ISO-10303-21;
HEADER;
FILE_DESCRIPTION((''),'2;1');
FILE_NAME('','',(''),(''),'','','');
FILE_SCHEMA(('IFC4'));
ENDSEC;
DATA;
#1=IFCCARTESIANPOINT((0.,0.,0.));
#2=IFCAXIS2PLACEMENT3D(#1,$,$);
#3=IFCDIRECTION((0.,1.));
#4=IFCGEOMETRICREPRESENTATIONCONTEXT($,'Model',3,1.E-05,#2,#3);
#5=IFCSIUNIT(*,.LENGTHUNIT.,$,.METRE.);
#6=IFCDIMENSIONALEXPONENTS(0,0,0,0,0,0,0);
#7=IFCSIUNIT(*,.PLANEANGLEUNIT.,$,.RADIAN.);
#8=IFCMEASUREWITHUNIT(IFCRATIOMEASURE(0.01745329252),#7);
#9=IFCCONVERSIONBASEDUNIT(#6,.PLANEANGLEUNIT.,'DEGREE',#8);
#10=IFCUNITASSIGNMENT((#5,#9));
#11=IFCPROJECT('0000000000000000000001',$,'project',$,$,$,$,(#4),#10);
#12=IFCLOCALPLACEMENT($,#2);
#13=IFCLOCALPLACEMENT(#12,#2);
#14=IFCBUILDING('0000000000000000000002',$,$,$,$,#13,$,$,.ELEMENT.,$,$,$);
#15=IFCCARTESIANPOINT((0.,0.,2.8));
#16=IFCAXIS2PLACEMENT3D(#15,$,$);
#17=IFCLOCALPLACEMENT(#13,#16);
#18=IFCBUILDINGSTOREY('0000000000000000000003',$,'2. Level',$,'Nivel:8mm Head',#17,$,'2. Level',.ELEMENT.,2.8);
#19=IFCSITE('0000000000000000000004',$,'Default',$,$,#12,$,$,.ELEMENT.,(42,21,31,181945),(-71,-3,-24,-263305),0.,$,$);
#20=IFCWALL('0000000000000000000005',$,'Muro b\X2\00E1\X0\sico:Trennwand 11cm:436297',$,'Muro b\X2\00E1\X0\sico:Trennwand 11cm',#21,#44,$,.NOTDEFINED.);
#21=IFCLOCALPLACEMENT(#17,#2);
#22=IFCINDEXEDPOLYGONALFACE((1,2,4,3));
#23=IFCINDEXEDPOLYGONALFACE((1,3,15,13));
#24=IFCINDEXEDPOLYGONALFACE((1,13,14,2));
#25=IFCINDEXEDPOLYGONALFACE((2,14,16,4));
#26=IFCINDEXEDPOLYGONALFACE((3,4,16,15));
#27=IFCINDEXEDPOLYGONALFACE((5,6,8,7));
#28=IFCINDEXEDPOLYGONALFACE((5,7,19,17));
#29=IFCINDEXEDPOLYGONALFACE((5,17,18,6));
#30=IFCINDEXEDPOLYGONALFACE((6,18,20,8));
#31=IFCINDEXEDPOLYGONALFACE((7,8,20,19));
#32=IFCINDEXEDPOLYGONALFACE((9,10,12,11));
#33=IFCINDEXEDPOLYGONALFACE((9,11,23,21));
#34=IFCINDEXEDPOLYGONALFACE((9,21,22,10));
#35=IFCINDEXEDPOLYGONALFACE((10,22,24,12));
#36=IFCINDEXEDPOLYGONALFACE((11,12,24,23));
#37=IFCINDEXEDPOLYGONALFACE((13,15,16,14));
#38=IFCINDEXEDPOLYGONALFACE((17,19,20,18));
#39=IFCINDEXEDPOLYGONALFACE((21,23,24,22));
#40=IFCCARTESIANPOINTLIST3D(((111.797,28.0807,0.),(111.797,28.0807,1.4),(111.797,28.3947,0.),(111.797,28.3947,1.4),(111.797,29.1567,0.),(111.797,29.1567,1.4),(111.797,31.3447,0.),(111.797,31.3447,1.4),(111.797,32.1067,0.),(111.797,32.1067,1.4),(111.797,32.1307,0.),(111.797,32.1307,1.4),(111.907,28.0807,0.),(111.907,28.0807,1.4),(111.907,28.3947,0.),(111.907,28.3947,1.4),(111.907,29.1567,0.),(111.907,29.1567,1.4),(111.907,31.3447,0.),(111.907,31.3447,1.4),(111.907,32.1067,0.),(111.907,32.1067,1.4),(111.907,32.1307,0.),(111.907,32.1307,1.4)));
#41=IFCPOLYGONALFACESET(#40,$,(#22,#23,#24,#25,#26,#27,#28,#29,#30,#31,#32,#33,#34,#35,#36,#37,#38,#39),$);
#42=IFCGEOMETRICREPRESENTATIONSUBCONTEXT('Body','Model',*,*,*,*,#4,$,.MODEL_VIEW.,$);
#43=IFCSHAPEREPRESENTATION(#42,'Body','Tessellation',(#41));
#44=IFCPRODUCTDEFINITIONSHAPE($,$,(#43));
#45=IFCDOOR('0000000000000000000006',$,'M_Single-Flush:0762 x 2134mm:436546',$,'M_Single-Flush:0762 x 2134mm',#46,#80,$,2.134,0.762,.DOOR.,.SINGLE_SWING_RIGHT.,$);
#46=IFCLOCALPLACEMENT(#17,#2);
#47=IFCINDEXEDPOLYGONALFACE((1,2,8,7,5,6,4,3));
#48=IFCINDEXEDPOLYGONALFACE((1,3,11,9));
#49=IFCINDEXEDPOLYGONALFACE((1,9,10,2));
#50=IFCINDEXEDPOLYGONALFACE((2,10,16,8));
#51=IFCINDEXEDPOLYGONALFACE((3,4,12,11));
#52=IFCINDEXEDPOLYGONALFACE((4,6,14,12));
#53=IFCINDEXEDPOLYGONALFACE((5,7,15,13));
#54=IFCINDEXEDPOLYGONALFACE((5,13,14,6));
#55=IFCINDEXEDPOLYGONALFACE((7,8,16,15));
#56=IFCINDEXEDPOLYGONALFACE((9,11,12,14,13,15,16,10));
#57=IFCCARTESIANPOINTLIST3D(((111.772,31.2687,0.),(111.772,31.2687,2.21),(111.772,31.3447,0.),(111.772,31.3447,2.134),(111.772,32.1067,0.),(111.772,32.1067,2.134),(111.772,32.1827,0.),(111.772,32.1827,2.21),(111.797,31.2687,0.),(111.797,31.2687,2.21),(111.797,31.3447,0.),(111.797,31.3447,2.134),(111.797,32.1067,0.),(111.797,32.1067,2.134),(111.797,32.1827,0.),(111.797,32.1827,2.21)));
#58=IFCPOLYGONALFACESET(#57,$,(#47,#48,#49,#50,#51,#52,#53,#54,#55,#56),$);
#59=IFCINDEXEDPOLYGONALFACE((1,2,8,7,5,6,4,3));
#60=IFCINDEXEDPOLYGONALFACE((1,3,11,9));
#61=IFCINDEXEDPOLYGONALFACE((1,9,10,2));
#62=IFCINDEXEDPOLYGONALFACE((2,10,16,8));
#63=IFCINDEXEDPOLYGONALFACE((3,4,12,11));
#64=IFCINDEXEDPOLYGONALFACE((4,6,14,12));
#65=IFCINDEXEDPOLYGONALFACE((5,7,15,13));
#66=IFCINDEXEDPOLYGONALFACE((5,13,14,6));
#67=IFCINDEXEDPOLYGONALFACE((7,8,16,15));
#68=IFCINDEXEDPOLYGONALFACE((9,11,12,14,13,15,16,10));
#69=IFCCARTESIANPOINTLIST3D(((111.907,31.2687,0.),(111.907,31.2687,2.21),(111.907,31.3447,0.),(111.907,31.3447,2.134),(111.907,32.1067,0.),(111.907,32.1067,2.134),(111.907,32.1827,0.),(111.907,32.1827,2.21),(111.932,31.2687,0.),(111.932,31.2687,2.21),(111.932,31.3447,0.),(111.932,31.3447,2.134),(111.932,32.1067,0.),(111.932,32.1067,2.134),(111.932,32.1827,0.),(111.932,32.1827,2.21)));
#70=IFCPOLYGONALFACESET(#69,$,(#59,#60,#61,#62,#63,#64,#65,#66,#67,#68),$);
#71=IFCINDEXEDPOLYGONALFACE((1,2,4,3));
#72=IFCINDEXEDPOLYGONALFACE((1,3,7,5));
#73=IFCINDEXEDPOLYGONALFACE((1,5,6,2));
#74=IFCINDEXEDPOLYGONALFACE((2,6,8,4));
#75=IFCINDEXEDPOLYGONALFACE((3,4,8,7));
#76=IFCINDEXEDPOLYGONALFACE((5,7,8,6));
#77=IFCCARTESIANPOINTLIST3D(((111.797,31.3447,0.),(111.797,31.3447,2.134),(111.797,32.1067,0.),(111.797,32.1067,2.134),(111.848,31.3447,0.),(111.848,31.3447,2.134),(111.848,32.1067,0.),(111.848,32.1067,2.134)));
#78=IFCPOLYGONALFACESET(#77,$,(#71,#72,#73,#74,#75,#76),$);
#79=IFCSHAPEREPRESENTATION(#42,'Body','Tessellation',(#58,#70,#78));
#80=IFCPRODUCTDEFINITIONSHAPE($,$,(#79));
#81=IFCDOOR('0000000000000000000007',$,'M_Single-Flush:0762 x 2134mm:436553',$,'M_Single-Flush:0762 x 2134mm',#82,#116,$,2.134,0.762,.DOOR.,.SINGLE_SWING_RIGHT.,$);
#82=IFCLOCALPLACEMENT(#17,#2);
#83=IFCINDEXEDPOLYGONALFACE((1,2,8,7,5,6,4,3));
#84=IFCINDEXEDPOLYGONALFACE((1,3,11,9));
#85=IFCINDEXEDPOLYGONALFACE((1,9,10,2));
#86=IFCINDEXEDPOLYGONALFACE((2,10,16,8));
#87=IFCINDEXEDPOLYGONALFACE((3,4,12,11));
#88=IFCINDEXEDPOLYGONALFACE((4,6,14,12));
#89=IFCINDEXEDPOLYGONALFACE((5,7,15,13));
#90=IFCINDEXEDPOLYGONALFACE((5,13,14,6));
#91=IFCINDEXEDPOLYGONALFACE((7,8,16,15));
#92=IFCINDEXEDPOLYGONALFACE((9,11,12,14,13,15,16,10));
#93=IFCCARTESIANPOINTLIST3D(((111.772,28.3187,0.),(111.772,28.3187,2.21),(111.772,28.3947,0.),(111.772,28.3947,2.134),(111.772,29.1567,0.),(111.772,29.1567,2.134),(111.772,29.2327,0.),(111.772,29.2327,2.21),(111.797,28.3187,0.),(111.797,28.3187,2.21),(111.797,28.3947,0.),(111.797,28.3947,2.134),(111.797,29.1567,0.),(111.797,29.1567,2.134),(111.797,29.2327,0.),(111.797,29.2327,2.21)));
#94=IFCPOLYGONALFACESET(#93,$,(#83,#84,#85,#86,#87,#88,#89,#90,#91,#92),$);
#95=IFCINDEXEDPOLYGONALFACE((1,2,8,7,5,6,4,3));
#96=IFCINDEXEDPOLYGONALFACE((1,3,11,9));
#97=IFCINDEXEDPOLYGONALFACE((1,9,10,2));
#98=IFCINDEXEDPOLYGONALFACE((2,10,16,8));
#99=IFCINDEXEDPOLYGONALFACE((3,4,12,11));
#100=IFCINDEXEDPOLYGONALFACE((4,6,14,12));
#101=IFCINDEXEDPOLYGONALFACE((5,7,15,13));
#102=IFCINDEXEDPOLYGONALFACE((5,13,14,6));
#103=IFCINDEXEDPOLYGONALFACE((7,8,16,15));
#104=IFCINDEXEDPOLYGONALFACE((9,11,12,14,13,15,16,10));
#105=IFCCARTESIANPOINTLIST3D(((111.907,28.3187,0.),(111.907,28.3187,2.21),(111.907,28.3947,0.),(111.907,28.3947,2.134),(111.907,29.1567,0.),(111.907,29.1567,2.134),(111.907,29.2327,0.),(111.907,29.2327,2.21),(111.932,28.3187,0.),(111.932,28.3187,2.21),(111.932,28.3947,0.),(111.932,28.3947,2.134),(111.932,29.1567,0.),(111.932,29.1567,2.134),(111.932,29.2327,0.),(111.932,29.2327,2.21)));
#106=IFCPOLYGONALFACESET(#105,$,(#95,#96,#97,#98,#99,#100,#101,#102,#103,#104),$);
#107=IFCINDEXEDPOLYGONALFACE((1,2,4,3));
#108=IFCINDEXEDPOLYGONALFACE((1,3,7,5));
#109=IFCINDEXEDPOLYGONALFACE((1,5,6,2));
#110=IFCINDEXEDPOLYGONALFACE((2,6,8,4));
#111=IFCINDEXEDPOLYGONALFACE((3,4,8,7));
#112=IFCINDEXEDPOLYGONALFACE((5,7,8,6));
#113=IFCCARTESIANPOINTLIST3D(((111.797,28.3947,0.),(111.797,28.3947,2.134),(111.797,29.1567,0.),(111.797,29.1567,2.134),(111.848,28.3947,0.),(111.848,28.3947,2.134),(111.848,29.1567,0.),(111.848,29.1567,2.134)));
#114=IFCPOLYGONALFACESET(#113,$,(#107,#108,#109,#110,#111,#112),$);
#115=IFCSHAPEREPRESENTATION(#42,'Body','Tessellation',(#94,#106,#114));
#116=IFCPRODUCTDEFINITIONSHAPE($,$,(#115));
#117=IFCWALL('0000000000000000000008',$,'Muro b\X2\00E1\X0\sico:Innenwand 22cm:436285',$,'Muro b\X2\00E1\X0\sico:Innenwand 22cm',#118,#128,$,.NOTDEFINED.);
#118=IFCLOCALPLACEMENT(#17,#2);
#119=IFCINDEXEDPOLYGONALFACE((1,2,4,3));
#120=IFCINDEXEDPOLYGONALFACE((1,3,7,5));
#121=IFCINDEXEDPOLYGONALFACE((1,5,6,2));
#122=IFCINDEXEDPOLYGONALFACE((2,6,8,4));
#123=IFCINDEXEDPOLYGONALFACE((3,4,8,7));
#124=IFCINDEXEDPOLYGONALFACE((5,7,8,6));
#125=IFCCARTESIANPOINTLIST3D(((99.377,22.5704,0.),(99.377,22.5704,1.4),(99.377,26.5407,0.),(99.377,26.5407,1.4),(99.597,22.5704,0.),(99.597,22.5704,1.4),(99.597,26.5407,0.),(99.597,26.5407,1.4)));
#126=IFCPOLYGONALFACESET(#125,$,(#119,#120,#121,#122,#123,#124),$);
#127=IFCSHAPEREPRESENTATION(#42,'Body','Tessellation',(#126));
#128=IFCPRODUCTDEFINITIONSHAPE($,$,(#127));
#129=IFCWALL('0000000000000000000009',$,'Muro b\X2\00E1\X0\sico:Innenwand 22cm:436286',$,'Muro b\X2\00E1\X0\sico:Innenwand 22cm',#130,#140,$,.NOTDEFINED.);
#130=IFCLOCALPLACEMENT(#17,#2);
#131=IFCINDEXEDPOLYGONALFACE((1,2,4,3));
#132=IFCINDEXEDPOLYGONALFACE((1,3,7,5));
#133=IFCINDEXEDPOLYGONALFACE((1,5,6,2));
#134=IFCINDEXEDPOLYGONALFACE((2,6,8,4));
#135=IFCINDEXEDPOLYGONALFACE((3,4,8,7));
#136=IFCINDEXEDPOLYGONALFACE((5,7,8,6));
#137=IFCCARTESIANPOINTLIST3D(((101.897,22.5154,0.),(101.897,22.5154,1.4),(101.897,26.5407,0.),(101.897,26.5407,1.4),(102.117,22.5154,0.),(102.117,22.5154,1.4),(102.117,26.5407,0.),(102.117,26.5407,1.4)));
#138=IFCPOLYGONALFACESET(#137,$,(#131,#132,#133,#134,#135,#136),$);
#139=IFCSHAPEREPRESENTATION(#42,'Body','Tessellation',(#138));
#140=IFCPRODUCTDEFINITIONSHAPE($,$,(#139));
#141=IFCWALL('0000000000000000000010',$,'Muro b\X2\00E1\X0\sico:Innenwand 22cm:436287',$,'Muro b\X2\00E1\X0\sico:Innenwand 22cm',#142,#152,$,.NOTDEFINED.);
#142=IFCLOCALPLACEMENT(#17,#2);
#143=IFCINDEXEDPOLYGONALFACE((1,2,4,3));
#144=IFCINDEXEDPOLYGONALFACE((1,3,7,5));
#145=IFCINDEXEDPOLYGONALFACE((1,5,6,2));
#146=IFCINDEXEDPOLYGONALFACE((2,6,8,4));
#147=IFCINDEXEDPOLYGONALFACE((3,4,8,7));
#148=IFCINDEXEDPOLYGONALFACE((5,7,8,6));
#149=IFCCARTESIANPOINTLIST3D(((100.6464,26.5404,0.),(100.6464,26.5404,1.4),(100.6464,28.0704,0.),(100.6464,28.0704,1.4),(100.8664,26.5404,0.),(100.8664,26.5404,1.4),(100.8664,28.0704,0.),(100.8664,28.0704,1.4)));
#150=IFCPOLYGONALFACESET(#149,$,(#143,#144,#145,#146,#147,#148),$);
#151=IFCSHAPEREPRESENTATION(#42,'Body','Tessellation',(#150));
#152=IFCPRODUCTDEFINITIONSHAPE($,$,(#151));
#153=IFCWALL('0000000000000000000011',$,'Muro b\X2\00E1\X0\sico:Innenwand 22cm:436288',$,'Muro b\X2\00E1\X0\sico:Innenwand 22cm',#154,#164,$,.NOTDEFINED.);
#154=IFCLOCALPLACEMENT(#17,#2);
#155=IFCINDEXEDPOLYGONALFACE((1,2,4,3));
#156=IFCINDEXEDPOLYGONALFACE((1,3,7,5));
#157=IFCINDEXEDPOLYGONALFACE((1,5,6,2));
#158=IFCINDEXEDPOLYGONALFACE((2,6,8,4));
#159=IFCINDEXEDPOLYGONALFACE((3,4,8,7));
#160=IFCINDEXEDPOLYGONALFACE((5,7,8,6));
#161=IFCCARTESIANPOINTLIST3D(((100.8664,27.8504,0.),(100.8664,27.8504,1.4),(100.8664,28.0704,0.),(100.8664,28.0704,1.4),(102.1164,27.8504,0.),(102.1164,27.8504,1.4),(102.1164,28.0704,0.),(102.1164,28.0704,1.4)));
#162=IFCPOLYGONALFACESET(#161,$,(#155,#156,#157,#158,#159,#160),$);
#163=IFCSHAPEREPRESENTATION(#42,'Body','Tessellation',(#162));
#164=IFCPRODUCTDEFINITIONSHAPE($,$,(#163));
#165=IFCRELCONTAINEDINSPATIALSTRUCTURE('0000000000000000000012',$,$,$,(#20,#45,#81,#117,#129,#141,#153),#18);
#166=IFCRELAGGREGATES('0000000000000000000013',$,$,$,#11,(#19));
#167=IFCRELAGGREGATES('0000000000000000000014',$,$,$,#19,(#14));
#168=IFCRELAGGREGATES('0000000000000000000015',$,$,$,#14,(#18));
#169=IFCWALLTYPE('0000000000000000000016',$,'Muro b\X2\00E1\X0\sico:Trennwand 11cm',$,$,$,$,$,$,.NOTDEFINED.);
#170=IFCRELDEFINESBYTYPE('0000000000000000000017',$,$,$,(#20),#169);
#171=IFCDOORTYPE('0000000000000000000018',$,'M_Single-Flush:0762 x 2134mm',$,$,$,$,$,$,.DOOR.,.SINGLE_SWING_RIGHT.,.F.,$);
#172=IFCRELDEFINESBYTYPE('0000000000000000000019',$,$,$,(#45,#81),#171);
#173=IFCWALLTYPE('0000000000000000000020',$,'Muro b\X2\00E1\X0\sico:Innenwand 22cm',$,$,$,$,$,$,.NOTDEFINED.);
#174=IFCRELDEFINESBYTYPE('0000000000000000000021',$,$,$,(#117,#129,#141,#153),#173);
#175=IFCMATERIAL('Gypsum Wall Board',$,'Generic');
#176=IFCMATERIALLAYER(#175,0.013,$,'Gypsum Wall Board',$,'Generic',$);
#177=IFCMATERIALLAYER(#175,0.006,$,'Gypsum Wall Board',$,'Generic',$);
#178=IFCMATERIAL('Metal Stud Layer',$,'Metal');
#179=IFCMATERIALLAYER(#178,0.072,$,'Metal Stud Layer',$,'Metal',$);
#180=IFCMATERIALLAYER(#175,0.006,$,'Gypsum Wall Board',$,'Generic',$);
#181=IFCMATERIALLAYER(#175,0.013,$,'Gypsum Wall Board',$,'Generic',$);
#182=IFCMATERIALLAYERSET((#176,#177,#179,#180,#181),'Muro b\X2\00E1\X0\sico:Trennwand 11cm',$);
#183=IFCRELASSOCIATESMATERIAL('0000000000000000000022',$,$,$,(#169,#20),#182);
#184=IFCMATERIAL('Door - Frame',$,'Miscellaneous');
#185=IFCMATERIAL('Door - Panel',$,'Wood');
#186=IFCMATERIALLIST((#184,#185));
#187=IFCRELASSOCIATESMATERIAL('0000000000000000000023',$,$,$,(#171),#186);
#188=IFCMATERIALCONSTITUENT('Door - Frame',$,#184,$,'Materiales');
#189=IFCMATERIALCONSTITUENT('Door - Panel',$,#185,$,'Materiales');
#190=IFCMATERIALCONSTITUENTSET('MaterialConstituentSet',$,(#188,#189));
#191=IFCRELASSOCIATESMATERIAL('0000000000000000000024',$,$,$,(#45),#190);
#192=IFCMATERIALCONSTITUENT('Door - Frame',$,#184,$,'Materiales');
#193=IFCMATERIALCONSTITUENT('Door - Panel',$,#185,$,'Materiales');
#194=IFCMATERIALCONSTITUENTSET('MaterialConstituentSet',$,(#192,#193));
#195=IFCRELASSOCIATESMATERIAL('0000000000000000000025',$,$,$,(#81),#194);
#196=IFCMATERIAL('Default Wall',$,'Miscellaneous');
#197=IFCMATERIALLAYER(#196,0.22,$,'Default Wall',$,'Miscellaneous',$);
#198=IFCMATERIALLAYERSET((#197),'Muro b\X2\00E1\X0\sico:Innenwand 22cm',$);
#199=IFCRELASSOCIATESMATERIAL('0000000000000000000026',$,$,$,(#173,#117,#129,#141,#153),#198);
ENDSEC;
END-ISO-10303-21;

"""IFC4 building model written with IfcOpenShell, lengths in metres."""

from ifc_helpers import new_model, entity, si_unit, converted_unit, direction, frame, frame_2d, origin, origin_2d_with_axis, place, context, subcontext, project, spatial, polyline, rectangle, outline, extrude, clip, halfspace, source, transform, mapped, material, material_list, layer, layer_set, layer_usage, constituent, constituent_set, type_object, type_shapes, element, fill, save


model = new_model("IFC4")

# Units and contexts
model_context = context("Model", 3, precision=1e-05, world=origin(), true_north=direction((0.0, 1.0)))
body_context = subcontext(model_context, "Body", "Model", "MODEL_VIEW")
ifc_project = project(units=[si_unit("LENGTHUNIT", "METRE"), converted_unit("PLANEANGLEUNIT", "DEGREE", entity("IfcRatioMeasure", 0.01745329252), si_unit("PLANEANGLEUNIT", "RADIAN"), dimensions=[0, 0, 0, 0, 0, 0, 0])], contexts=[model_context])

# Site, building, storey
site_placement = place(None, origin())
site = spatial("IfcSite", under=ifc_project, at=site_placement, Name="Default", CompositionType="ELEMENT", RefLatitude=(42, 21, 31, 181945), RefLongitude=(-71, -3, -24, -263305), RefElevation=0.0)
building_placement = place(site_placement, origin())
building = spatial("IfcBuilding", under=site, at=building_placement, CompositionType="ELEMENT")
storey_placement = place(building_placement, frame((0.0, 0.0, 2.8)))
storey = spatial("IfcBuildingStorey", under=building, at=storey_placement, Name="2. Level", ObjectType="Nivel:8mm Head", LongName="2. Level", CompositionType="ELEMENT", Elevation=2.8)

# Shared definitions
ifc_material_1 = material(Name="Gypsum Wall Board", Category="Generic")
ifc_layer_1 = layer(ifc_material_1, 0.013, Name="Gypsum Wall Board", Category="Generic")
ifc_layer_2 = layer(ifc_material_1, 0.006, Name="Gypsum Wall Board", Category="Generic")
ifc_material_2 = material(Name="Metal Stud Layer", Category="Metal")
ifc_layer_3 = layer(ifc_material_2, 0.072, Name="Metal Stud Layer", Category="Metal")
ifc_layer_4 = layer(ifc_material_1, 0.006, Name="Gypsum Wall Board", Category="Generic")
ifc_layer_5 = layer(ifc_material_1, 0.013, Name="Gypsum Wall Board", Category="Generic")
ifc_layer_set_1 = layer_set([ifc_layer_1, ifc_layer_2, ifc_layer_3, ifc_layer_4, ifc_layer_5], Name="Muro básico:Trennwand 11cm")
wall_type_1 = type_object("IfcWallType", Name="Muro básico:Trennwand 11cm", PredefinedType="NOTDEFINED", material=ifc_layer_set_1)

# Shared definitions
ifc_material_3 = material(Name="Door - Frame", Category="Miscellaneous")
ifc_material_4 = material(Name="Door - Panel", Category="Wood")

# Wall, openings, doors
ifc_material_list_1 = material_list([ifc_material_3, ifc_material_4])
door_type_1 = type_object("IfcDoorType", Name="M_Single-Flush:0762 x 2134mm", OperationType="SINGLE_SWING_RIGHT", ParameterTakesPrecedence=False, PredefinedType="DOOR", material=ifc_material_list_1)
shared_shape_1 = source(origin(), body_context, "Body", "SweptSolid", [
    extrude(outline(polyline([(-0.457, -1.124), (0.457, -1.124), (0.457, 1.086), (0.381, 1.086), (0.381, -1.048), (-0.381, -1.048), (-0.381, 1.086), (-0.457, 1.086), (-0.457, -1.124)])), frame((0.381, 0.11, 1.086), z_axis=(0.0, 1.0, 0.0), x_axis=(1.0, 0.0, 0.0)), (0.0, 0.0, 1.0), 0.025),
    extrude(outline(polyline([(-1.124, -0.457), (1.086, -0.457), (1.086, -0.381), (-1.048, -0.381), (-1.048, 0.381), (1.086, 0.381), (1.086, 0.457), (-1.124, 0.457), (-1.124, -0.457)])), frame((0.381, -0.025, 1.086), z_axis=(0.0, 1.0, 0.0), x_axis=(0.0, 0.0, -1.0)), (0.0, 0.0, 1.0), 0.025),
    extrude(rectangle(XDim=0.051, YDim=0.762, at=origin_2d_with_axis()), frame((0.381, 0.0845, 0.0), z_axis=(0.0, 0.0, 1.0), x_axis=(0.0, 1.0, 0.0)), (0.0, 0.0, 1.0), 2.134),
])
type_shapes(door_type_1, [shared_shape_1])
ifc_layer_usage_1 = layer_usage(ifc_layer_set_1, "AXIS2", "NEGATIVE", 0.055)
wall_1_placement = place(storey_placement, frame((111.852, 28.0807, 0.0), z_axis=(0.0, 0.0, 1.0), x_axis=(0.0, 1.0, 0.0)))
wall_1 = element("IfcWall", 1, at=wall_1_placement, inside=storey, type_object=wall_type_1, material=ifc_layer_usage_1, Name="Muro básico:Trennwand 11cm:436297", ObjectType="Muro básico:Trennwand 11cm", PredefinedType="NOTDEFINED", context=body_context, shape_type="Clipping", body=[
    clip(extrude(rectangle(XDim=4.05, YDim=0.11, at=frame_2d((2.025, 0.0), x_axis=(-1.0, 0.0))), origin(), (0.0, 0.0, 1.0), 1.4), halfspace(origin(), True)),
])
opening_1_placement = place(wall_1_placement, frame((3.264, -0.055, 0.0)))
opening_1 = element("IfcOpeningElement", 2, at=opening_1_placement, cuts=wall_1, ObjectType="Opening", PredefinedType="OPENING", context=body_context, shape_type="SweptSolid", body=[
    extrude(rectangle(XDim=0.762, YDim=2.134, at=frame_2d((1.067, 0.381), x_axis=(0.0, 1.0))), frame((0.0, 0.0, 0.0), z_axis=(0.0, 1.0, 0.0), x_axis=(0.0, 0.0, 1.0)), (0.0, 0.0, 1.0), 0.11),
])
opening_2_placement = place(wall_1_placement, frame((0.314, -0.055, 0.0)))
opening_2 = element("IfcOpeningElement", 3, at=opening_2_placement, cuts=wall_1, ObjectType="Opening", PredefinedType="OPENING", context=body_context, shape_type="SweptSolid", body=[
    extrude(rectangle(XDim=0.762, YDim=2.134, at=frame_2d((1.067, 0.381), x_axis=(0.0, 1.0))), frame((0.0, 0.0, 0.0), z_axis=(0.0, 1.0, 0.0), x_axis=(0.0, 0.0, 1.0)), (0.0, 0.0, 1.0), 0.11),
])
ifc_constituent_1 = constituent(ifc_material_3, Name="Door - Frame", Category="Materiales")
ifc_constituent_2 = constituent(ifc_material_4, Name="Door - Panel", Category="Materiales")
ifc_constituent_set_1 = constituent_set(constituents=[ifc_constituent_1, ifc_constituent_2], Name="MaterialConstituentSet")
door_1_placement = place(opening_1_placement, origin())
door_1 = element("IfcDoor", 4, at=door_1_placement, inside=storey, type_object=door_type_1, material=ifc_constituent_set_1, Name="M_Single-Flush:0762 x 2134mm:436546", ObjectType="M_Single-Flush:0762 x 2134mm", OperationType="SINGLE_SWING_RIGHT", OverallHeight=2.134, OverallWidth=0.762, PredefinedType="DOOR", context=body_context, shape_type="MappedRepresentation", body=[
    mapped(shared_shape_1, transform((0.0, 0.0, 0.0), scale=1.0)),
])
fill(opening_1, door_1)
ifc_constituent_3 = constituent(ifc_material_3, Name="Door - Frame", Category="Materiales")
ifc_constituent_4 = constituent(ifc_material_4, Name="Door - Panel", Category="Materiales")
ifc_constituent_set_2 = constituent_set(constituents=[ifc_constituent_3, ifc_constituent_4], Name="MaterialConstituentSet")
door_2_placement = place(opening_2_placement, origin())
door_2 = element("IfcDoor", 5, at=door_2_placement, inside=storey, type_object=door_type_1, material=ifc_constituent_set_2, Name="M_Single-Flush:0762 x 2134mm:436553", ObjectType="M_Single-Flush:0762 x 2134mm", OperationType="SINGLE_SWING_RIGHT", OverallHeight=2.134, OverallWidth=0.762, PredefinedType="DOOR", context=body_context, shape_type="MappedRepresentation", body=[
    mapped(shared_shape_1, transform((0.0, 0.0, 0.0), scale=1.0)),
])
fill(opening_2, door_2)

# Walls
ifc_material_5 = material(Name="Default Wall", Category="Miscellaneous")
ifc_layer_6 = layer(ifc_material_5, 0.22, Name="Default Wall", Category="Miscellaneous")
ifc_layer_set_2 = layer_set([ifc_layer_6], Name="Muro básico:Innenwand 22cm")
ifc_layer_usage_2 = layer_usage(ifc_layer_set_2, "AXIS2", "NEGATIVE", 0.11)
wall_type_2 = type_object("IfcWallType", Name="Muro básico:Innenwand 22cm", PredefinedType="NOTDEFINED", material=ifc_layer_set_2)
wall_2_placement = place(storey_placement, frame((99.487, 22.5704, 0.0), z_axis=(0.0, 0.0, 1.0), x_axis=(0.0, 1.0, 0.0)))
element("IfcWall", 6, at=wall_2_placement, inside=storey, type_object=wall_type_2, material=ifc_layer_usage_2, Name="Muro básico:Innenwand 22cm:436285", ObjectType="Muro básico:Innenwand 22cm", PredefinedType="NOTDEFINED", context=body_context, shape_type="Clipping", body=[
    clip(extrude(rectangle(XDim=3.9703, YDim=0.22, at=frame_2d((1.9852, 0.0), x_axis=(-1.0, 0.0))), origin(), (0.0, 0.0, 1.0), 1.4), halfspace(origin(), True)),
])
ifc_layer_usage_3 = layer_usage(ifc_layer_set_2, "AXIS2", "NEGATIVE", 0.11)
wall_3_placement = place(storey_placement, frame((102.007, 22.5154, 0.0), z_axis=(0.0, 0.0, 1.0), x_axis=(0.0, 1.0, 0.0)))
element("IfcWall", 7, at=wall_3_placement, inside=storey, type_object=wall_type_2, material=ifc_layer_usage_3, Name="Muro básico:Innenwand 22cm:436286", ObjectType="Muro básico:Innenwand 22cm", PredefinedType="NOTDEFINED", context=body_context, shape_type="Clipping", body=[
    clip(extrude(rectangle(XDim=4.0253, YDim=0.22, at=frame_2d((2.0127, 0.0), x_axis=(-1.0, 0.0))), origin(), (0.0, 0.0, 1.0), 1.4), halfspace(origin(), True)),
])
ifc_layer_usage_4 = layer_usage(ifc_layer_set_2, "AXIS2", "NEGATIVE", 0.11)
wall_4_placement = place(storey_placement, frame((100.7564, 26.5404, 0.0), z_axis=(0.0, 0.0, 1.0), x_axis=(0.0, 1.0, 0.0)))
element("IfcWall", 8, at=wall_4_placement, inside=storey, type_object=wall_type_2, material=ifc_layer_usage_4, Name="Muro básico:Innenwand 22cm:436287", ObjectType="Muro básico:Innenwand 22cm", PredefinedType="NOTDEFINED", context=body_context, shape_type="Clipping", body=[
    clip(extrude(rectangle(XDim=1.53, YDim=0.22, at=frame_2d((0.765, 0.0), x_axis=(-1.0, 0.0))), origin(), (0.0, 0.0, 1.0), 1.4), halfspace(origin(), True)),
])
ifc_layer_usage_5 = layer_usage(ifc_layer_set_2, "AXIS2", "NEGATIVE", 0.11)
wall_5_placement = place(storey_placement, frame((100.8664, 27.9604, 0.0)))
element("IfcWall", 9, at=wall_5_placement, inside=storey, type_object=wall_type_2, material=ifc_layer_usage_5, Name="Muro básico:Innenwand 22cm:436288", ObjectType="Muro básico:Innenwand 22cm", PredefinedType="NOTDEFINED", context=body_context, shape_type="Clipping", body=[
    clip(extrude(rectangle(XDim=1.25, YDim=0.22, at=frame_2d((0.625, 0.0), x_axis=(-1.0, 0.0))), origin(), (0.0, 0.0, 1.0), 1.4), halfspace(origin(), True)),
])

save(model, "model.ifc")
